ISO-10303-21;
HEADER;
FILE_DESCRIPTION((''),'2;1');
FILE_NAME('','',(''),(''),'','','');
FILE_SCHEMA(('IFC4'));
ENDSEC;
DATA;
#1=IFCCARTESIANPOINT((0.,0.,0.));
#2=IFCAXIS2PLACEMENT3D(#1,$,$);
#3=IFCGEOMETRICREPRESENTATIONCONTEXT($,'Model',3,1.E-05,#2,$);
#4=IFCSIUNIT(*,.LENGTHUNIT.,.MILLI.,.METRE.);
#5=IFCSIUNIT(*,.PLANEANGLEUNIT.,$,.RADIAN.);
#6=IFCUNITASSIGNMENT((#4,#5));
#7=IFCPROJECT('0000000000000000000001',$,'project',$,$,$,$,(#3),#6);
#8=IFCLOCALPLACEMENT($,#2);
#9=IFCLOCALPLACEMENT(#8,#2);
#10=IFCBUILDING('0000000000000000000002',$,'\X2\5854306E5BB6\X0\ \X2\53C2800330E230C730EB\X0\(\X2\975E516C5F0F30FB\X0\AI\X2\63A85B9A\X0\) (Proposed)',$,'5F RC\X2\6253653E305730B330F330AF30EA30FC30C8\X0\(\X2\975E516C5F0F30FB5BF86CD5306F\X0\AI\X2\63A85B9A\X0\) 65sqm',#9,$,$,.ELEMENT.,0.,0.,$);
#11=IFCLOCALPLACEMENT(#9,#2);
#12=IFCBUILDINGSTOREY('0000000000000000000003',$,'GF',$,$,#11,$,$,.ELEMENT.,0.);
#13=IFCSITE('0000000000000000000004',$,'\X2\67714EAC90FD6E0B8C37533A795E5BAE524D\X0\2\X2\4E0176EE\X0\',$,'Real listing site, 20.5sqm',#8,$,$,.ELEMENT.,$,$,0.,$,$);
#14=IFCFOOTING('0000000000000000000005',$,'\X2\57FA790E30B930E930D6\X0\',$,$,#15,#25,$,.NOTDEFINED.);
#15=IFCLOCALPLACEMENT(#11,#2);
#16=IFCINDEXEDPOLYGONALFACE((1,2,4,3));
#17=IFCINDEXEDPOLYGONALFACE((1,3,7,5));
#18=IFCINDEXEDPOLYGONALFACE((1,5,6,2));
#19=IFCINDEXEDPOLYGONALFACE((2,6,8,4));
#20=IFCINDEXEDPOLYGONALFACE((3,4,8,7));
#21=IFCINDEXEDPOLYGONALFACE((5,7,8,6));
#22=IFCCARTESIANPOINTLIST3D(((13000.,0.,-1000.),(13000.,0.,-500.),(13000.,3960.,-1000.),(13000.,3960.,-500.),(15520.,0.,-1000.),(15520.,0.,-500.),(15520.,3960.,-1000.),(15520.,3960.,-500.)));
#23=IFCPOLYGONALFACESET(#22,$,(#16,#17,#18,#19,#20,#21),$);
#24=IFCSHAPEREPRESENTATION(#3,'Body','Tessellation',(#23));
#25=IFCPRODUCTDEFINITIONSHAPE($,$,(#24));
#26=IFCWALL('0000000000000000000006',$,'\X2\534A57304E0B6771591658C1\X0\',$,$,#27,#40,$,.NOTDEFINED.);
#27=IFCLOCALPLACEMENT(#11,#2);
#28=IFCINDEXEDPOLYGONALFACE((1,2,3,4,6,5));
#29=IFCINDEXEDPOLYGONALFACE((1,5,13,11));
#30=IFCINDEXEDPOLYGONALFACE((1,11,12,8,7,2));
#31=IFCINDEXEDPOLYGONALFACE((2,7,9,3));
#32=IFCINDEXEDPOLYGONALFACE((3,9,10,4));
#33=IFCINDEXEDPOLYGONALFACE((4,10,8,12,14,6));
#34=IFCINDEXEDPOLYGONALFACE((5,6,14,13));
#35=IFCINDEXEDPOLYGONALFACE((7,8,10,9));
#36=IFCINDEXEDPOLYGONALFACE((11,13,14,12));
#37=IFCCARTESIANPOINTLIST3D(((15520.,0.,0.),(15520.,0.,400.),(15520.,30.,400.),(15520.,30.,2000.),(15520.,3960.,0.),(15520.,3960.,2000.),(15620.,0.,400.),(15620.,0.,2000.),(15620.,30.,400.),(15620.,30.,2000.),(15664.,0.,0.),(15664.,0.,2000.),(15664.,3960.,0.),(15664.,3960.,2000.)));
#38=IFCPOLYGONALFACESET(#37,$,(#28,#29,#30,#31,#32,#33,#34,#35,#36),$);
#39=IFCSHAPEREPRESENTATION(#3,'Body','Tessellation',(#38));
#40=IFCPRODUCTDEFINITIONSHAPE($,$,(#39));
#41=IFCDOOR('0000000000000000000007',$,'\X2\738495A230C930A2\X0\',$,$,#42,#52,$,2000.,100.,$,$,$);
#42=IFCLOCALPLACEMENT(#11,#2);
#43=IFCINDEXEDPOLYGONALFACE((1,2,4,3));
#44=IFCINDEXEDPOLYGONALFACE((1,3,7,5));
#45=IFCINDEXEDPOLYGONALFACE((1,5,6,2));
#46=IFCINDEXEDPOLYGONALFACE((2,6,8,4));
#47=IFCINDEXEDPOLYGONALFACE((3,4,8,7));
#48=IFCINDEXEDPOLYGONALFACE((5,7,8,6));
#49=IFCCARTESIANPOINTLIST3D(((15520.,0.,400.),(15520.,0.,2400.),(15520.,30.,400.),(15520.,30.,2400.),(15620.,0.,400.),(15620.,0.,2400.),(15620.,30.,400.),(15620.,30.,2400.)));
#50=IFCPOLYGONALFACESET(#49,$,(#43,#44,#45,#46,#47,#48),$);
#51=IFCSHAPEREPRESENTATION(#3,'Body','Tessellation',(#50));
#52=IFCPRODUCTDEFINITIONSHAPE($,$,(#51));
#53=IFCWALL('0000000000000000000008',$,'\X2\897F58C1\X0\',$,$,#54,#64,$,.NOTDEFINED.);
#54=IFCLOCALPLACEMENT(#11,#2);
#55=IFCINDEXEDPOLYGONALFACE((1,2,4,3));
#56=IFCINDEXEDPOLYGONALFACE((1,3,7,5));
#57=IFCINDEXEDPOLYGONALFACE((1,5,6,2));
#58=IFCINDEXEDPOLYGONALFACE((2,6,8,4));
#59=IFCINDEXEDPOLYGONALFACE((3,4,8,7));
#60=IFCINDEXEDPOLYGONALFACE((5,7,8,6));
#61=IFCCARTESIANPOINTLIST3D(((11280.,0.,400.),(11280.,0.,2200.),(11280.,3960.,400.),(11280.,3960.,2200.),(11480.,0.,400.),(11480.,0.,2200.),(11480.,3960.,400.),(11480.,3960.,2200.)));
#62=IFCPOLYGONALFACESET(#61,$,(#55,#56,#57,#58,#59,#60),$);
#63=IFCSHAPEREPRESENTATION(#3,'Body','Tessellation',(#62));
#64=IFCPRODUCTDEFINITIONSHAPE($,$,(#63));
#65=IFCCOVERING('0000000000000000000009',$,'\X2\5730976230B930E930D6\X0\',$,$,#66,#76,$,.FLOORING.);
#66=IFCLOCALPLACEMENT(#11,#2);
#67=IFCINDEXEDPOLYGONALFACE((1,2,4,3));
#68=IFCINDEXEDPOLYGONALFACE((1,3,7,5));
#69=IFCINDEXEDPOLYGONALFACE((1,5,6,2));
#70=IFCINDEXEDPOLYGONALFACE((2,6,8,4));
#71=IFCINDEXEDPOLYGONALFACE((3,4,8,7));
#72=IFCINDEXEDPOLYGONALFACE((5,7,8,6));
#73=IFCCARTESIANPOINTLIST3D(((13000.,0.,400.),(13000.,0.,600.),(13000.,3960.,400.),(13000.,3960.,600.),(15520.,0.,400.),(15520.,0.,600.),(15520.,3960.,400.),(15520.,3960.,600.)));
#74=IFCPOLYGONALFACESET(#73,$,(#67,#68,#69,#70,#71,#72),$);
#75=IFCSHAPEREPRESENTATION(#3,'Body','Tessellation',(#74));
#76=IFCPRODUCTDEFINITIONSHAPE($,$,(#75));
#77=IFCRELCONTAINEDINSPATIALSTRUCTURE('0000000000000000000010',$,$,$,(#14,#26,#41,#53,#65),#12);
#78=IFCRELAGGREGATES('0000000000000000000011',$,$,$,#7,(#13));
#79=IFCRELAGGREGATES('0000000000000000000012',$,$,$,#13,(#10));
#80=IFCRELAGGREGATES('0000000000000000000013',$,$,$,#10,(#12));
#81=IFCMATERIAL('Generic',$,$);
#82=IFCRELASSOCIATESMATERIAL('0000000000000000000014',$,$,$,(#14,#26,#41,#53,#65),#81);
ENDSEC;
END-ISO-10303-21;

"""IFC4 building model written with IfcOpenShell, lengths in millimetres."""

from ifc_helpers import new_model, si_unit, frame, frame_2d, origin, place, context, project, spatial, rectangle, extrude, material, element, fill, save


model = new_model("IFC4")

# Units and contexts
model_context = context("Model", 3, precision=1e-05, world=origin())
ifc_project = project(units=[si_unit("LENGTHUNIT", "METRE", prefix="MILLI"), si_unit("PLANEANGLEUNIT", "RADIAN")], contexts=[model_context])

# Site, building, storey
site_placement = place(None, origin())
site = spatial("IfcSite", under=ifc_project, at=site_placement, Name="東京都渋谷区神宮前2丁目", ObjectType="Real listing site, 20.5sqm", CompositionType="ELEMENT", RefElevation=0.0)
building_placement = place(site_placement, origin())
building = spatial("IfcBuilding", under=site, at=building_placement, Name="塔の家 参考モデル(非公式・AI推定) (Proposed)", ObjectType="5F RC打放しコンクリート(非公式・寸法はAI推定) 65sqm", CompositionType="ELEMENT", ElevationOfRefHeight=0.0, ElevationOfTerrain=0.0)
storey_placement = place(building_placement, origin())
storey = spatial("IfcBuildingStorey", under=building, at=storey_placement, Name="GF", CompositionType="ELEMENT", Elevation=0.0)

# Footing
ifc_material = material(Name="Generic")
footing_1_placement = place(storey_placement, frame((6500.0, 0.0, -500.0)))
element("IfcFooting", 1, at=footing_1_placement, inside=storey, material=ifc_material, Name="基礎スラブ", PredefinedType="NOTDEFINED", context=model_context, shape_type="SweptSolid", body=[
    extrude(rectangle(XDim=2520.0, YDim=3960.0, at=frame_2d((1260.0, 1980.0))), frame((6500.0, 0.0, -500.0)), (0.0, 0.0, 1.0), 500.0),
])

# Wall, opening, door
wall_1_placement = place(storey_placement, frame((7760.0, 0.0, 0.0)))
wall_1 = element("IfcWall", 2, at=wall_1_placement, inside=storey, material=ifc_material, Name="半地下東外壁", PredefinedType="NOTDEFINED", context=model_context, shape_type="SweptSolid", body=[
    extrude(rectangle(XDim=144.0, YDim=3960.0, at=frame_2d((72.0, 1980.0))), frame((7760.0, 0.0, 0.0)), (0.0, 0.0, 1.0), 2000.0),
])
opening_1_placement = place(storey_placement, frame((7760.0, 0.0, 200.0)))
opening_1 = element("IfcOpeningElement", 3, at=opening_1_placement, cuts=wall_1, PredefinedType="NOTDEFINED", context=model_context, shape_type="SweptSolid", body=[
    extrude(rectangle(XDim=100.0, YDim=30.0, at=frame_2d((50.0, 15.0))), frame((7760.0, 0.0, 200.0)), (0.0, 0.0, 1.0), 2000.0),
])
door_1_placement = place(storey_placement, frame((7760.0, 0.0, 200.0)))
door_1 = element("IfcDoor", 4, at=door_1_placement, inside=storey, material=ifc_material, Name="玄関ドア", OverallHeight=2000.0, OverallWidth=100.0, context=model_context, shape_type="SweptSolid", body=[
    extrude(rectangle(XDim=100.0, YDim=30.0, at=frame_2d((50.0, 15.0))), frame((7760.0, 0.0, 200.0)), (0.0, 0.0, 1.0), 2000.0),
])
fill(opening_1, door_1)

# Wall
wall_2_placement = place(storey_placement, frame((5640.0, 0.0, 200.0)))
element("IfcWall", 5, at=wall_2_placement, inside=storey, material=ifc_material, Name="西壁", PredefinedType="NOTDEFINED", context=model_context, shape_type="SweptSolid", body=[
    extrude(rectangle(XDim=200.0, YDim=3960.0, at=frame_2d((100.0, 1980.0))), frame((5640.0, 0.0, 200.0)), (0.0, 0.0, 1.0), 1800.0),
])

# Covering
covering_1_placement = place(storey_placement, frame((6500.0, 0.0, 200.0)))
element("IfcCovering", 6, at=covering_1_placement, inside=storey, material=ifc_material, Name="地面スラブ", PredefinedType="FLOORING", context=model_context, shape_type="SweptSolid", body=[
    extrude(rectangle(XDim=2520.0, YDim=3960.0, at=frame_2d((1260.0, 1980.0))), frame((6500.0, 0.0, 200.0)), (0.0, 0.0, 1.0), 200.0),
])

save(model, "model.ifc")
